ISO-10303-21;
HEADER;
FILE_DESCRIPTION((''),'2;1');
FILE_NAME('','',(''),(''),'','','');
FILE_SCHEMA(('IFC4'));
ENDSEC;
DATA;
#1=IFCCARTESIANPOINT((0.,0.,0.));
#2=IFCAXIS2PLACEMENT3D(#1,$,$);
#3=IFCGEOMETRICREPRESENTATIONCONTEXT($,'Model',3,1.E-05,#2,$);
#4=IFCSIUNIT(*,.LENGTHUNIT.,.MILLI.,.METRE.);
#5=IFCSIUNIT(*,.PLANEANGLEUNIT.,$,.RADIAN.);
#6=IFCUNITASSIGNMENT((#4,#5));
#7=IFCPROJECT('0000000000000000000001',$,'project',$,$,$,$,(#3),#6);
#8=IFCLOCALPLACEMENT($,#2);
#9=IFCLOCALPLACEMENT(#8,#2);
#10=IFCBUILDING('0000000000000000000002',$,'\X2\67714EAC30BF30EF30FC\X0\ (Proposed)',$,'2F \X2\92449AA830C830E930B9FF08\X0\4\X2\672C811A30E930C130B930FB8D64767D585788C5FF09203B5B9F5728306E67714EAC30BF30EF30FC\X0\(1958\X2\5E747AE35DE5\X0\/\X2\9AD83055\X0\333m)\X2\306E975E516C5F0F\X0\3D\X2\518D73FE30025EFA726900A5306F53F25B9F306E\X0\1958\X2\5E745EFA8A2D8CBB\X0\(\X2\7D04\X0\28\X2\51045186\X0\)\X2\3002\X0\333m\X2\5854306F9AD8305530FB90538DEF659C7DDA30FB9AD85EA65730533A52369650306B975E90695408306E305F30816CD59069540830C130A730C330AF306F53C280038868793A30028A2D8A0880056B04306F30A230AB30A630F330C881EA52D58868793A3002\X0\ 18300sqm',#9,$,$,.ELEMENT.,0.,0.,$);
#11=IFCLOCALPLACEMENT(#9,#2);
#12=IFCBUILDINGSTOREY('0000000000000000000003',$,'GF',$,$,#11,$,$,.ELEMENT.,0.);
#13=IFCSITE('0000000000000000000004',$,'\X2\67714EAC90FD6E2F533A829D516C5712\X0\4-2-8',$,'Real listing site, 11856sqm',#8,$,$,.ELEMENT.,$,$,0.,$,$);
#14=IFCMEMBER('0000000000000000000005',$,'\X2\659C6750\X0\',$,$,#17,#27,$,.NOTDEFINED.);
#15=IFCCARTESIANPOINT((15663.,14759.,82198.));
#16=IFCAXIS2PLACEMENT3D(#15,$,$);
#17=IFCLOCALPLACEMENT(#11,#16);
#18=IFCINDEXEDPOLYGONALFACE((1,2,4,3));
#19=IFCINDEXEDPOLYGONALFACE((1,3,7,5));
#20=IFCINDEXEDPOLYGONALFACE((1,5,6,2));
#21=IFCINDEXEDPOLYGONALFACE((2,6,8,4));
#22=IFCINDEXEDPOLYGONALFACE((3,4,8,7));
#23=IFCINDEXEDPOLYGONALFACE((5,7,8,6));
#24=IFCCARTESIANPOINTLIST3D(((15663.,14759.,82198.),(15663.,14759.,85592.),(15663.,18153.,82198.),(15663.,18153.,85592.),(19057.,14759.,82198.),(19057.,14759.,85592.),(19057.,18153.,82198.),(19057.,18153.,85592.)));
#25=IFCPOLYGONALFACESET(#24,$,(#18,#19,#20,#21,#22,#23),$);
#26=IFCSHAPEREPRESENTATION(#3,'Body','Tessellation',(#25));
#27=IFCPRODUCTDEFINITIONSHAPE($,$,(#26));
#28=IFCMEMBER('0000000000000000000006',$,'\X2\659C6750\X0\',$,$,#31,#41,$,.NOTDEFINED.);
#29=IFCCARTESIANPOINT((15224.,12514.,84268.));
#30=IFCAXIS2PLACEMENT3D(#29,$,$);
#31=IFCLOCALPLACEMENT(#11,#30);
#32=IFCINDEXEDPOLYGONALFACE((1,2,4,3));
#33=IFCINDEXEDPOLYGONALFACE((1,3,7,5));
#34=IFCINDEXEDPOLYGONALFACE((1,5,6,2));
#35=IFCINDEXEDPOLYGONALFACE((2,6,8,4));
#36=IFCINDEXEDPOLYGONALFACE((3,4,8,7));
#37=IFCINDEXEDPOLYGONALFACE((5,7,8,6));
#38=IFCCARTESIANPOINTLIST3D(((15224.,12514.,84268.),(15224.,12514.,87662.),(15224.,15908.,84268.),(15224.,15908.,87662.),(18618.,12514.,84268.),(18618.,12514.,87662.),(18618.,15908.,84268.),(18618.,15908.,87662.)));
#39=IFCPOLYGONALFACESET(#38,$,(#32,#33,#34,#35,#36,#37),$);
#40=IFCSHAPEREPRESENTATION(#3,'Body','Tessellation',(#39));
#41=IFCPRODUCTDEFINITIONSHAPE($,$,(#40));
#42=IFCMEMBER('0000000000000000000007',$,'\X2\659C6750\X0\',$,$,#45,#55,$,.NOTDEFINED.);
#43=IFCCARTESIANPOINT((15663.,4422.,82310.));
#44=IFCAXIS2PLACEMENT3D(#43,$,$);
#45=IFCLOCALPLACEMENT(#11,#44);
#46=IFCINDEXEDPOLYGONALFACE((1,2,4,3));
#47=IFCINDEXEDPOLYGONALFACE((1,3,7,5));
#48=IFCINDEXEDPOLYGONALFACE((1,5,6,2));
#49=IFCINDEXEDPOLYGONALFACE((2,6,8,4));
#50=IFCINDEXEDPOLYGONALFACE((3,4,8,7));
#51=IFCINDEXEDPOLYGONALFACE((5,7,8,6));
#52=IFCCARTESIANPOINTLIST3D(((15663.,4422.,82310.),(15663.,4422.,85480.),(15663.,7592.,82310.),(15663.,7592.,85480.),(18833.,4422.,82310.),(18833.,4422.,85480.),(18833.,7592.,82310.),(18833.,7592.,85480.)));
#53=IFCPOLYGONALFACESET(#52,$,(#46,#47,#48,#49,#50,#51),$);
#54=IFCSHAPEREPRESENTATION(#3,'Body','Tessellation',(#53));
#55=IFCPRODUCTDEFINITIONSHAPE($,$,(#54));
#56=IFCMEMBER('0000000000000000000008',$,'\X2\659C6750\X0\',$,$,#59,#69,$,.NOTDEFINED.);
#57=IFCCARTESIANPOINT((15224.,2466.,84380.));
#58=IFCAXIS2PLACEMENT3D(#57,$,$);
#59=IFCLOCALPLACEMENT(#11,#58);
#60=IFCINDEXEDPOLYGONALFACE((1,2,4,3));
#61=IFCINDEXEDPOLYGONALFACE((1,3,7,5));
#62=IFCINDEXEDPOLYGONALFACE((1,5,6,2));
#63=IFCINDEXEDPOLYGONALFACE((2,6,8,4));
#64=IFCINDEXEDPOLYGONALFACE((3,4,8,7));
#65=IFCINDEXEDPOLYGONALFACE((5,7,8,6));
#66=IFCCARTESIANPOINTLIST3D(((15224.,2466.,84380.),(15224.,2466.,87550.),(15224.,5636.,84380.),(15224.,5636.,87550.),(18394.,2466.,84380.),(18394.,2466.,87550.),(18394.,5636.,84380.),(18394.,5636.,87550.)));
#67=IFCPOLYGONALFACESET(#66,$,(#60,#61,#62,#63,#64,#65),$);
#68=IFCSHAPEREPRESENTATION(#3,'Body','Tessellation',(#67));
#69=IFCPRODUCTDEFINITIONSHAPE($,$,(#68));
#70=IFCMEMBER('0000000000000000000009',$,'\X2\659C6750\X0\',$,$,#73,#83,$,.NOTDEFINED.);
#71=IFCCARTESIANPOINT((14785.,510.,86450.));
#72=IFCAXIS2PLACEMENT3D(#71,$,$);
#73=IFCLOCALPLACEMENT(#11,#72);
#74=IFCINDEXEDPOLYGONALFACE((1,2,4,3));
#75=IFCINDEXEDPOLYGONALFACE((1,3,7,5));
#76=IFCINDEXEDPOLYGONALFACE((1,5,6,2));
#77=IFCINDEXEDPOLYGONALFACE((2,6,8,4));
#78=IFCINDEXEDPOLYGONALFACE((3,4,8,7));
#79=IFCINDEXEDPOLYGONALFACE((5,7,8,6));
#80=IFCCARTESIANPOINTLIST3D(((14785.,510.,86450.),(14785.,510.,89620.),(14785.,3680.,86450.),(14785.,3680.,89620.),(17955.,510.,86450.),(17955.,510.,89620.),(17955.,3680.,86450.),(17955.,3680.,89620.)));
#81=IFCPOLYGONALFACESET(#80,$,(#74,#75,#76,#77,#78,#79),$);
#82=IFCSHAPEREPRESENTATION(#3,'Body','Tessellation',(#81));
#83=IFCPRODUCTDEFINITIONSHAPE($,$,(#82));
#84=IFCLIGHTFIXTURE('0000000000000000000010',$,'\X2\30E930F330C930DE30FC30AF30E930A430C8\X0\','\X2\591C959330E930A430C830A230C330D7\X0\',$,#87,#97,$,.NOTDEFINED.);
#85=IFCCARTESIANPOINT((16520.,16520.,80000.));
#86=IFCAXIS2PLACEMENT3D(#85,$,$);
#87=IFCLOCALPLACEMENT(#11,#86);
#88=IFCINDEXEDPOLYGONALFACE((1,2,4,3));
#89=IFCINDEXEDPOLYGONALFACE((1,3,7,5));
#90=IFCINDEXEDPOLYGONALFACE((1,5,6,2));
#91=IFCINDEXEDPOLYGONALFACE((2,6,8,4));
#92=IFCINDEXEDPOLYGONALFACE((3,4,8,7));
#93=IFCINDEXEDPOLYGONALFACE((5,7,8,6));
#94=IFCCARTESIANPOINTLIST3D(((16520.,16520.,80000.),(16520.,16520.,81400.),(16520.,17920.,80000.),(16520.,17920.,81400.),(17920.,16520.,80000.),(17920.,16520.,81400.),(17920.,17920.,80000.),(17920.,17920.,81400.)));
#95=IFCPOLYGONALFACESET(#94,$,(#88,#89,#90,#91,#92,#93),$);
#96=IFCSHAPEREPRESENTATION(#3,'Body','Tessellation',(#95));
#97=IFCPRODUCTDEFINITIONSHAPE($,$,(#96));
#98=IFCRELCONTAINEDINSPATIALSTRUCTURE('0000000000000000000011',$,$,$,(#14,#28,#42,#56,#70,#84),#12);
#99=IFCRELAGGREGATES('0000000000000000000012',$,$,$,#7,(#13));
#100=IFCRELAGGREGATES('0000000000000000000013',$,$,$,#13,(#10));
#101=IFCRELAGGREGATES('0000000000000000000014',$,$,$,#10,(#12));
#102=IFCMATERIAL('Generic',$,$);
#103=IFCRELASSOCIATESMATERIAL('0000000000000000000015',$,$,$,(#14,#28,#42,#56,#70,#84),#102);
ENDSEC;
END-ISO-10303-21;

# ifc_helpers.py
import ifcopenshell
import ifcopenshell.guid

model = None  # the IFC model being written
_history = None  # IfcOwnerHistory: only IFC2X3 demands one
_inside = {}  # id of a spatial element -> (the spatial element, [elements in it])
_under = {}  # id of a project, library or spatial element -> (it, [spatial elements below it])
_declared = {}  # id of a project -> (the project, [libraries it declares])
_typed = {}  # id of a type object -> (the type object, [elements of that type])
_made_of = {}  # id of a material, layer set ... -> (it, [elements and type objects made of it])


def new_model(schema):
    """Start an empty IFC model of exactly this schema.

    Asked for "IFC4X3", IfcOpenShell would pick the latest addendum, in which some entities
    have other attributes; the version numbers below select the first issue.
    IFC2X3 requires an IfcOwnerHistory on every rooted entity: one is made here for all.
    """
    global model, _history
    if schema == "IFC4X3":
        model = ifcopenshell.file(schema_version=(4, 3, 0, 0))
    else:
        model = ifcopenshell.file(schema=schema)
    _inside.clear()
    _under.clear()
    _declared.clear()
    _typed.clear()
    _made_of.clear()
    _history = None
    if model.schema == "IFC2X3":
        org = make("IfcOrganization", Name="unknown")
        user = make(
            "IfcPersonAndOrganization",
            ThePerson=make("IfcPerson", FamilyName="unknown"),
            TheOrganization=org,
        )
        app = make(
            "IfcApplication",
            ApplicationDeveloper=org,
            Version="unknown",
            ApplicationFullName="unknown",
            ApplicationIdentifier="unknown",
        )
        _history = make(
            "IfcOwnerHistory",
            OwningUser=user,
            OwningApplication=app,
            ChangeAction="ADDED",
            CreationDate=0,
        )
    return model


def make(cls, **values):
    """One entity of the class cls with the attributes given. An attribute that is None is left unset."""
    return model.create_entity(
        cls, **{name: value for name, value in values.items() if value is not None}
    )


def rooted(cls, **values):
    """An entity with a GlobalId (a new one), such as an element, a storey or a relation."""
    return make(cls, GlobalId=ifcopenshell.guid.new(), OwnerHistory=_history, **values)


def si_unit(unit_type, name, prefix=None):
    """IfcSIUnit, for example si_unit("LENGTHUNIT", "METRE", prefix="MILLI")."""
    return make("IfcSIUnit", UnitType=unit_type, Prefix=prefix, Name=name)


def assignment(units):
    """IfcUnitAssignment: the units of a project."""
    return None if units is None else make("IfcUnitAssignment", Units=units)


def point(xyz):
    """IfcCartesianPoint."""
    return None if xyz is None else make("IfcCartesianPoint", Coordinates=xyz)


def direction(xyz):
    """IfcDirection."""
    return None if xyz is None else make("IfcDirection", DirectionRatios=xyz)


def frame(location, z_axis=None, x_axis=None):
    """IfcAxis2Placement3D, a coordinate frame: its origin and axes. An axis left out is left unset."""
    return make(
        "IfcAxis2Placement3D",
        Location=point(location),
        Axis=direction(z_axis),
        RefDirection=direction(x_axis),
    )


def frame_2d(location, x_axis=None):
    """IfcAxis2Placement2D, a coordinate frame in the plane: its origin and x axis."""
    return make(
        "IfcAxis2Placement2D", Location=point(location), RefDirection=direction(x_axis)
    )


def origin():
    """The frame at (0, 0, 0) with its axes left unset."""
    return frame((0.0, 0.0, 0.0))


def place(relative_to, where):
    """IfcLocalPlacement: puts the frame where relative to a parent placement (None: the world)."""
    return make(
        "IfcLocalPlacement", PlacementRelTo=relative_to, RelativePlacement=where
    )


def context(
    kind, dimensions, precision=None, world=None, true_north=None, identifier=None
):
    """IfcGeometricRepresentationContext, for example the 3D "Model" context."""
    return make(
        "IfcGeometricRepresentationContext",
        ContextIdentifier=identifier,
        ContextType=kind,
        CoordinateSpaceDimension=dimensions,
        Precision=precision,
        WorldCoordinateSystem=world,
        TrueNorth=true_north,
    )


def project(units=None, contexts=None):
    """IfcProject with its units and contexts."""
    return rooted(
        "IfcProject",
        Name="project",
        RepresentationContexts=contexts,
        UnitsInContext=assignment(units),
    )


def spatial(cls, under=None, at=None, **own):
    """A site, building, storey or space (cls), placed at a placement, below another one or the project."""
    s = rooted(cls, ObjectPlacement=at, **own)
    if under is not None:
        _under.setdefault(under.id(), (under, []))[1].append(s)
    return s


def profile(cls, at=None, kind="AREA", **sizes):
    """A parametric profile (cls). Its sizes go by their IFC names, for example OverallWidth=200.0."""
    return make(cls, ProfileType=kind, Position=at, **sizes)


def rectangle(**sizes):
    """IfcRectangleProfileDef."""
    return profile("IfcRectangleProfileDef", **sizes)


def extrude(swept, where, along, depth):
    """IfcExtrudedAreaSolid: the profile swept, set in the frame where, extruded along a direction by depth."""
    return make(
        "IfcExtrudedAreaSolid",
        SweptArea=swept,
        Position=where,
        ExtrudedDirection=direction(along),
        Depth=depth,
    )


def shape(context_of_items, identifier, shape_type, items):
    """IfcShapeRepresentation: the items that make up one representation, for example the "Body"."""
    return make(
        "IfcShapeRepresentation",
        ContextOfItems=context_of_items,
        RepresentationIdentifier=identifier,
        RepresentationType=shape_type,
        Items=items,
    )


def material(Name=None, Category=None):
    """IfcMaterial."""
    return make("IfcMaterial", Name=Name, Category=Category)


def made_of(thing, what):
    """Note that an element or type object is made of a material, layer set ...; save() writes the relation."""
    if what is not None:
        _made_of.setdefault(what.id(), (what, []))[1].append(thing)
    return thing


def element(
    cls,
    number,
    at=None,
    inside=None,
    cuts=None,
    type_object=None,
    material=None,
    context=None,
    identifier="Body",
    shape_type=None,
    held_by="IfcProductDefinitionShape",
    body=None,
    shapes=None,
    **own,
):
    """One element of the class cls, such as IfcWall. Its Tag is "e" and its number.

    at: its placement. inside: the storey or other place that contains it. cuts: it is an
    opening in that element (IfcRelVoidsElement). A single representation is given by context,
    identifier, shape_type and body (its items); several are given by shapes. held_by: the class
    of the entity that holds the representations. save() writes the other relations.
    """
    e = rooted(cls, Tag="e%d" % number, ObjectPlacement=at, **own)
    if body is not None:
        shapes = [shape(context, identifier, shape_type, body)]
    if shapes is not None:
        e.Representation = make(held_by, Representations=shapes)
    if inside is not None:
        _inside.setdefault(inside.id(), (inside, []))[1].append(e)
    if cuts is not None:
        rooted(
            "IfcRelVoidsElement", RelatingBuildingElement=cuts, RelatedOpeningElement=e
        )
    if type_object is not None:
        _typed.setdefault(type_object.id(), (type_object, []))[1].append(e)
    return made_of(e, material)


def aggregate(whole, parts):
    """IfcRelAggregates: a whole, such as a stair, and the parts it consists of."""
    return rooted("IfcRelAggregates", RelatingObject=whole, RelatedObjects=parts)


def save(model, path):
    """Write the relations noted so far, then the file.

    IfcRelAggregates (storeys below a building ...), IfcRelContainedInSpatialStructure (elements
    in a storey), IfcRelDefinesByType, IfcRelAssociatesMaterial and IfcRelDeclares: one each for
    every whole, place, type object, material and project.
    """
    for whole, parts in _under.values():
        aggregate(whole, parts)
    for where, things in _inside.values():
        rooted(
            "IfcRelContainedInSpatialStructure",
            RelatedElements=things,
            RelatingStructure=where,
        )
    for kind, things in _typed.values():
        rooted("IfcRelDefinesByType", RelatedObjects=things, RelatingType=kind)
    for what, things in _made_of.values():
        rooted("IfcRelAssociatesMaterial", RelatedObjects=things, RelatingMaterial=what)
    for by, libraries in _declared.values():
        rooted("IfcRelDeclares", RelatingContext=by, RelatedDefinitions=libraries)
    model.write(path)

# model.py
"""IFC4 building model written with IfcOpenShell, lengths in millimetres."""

from ifc_helpers import new_model, si_unit, frame, frame_2d, origin, place, context, project, spatial, rectangle, extrude, material, element, save


model = new_model("IFC4")

# Units and contexts
model_context = context("Model", 3, precision=1e-05, world=origin())
ifc_project = project(units=[si_unit("LENGTHUNIT", "METRE", prefix="MILLI"), si_unit("PLANEANGLEUNIT", "RADIAN")], contexts=[model_context])

# Site, building, storey
site_placement = place(None, origin())
site = spatial("IfcSite", under=ifc_project, at=site_placement, Name="東京都港区芝公園4-2-8", ObjectType="Real listing site, 11856sqm", CompositionType="ELEMENT", RefElevation=0.0)
building_placement = place(site_placement, origin())
building = spatial("IfcBuilding", under=site, at=building_placement, Name="東京タワー (Proposed)", ObjectType="2F 鉄骨トラス（4本脚ラチス・赤白塗装）※実在の東京タワー(1958年竣工/高さ333m)の非公式3D再現。建物¥は史実の1958年建設費(約28億円)。333m塔は高さ・道路斜線・高度地区制限に非適合のため法適合チェックは参考表示。設計者欄はアカウント自動表示。 18300sqm", CompositionType="ELEMENT", ElevationOfRefHeight=0.0, ElevationOfTerrain=0.0)
storey_placement = place(building_placement, origin())
storey = spatial("IfcBuildingStorey", under=building, at=storey_placement, Name="GF", CompositionType="ELEMENT", Elevation=0.0)

# Shared definitions
ifc_material = material(Name="Generic")

# Members
member_1_placement = place(storey_placement, frame((15663.0, 14759.0, 82198.0)))
element("IfcMember", 1, at=member_1_placement, inside=storey, material=ifc_material, Name="斜材", PredefinedType="NOTDEFINED", context=model_context, shape_type="SweptSolid", body=[
    extrude(rectangle(XDim=3394.0, YDim=3394.0, at=frame_2d((1697.0, 1697.0))), frame((15663.0, 14759.0, 82198.0)), (0.0, 0.0, 1.0), 3394.0),
])
member_2_placement = place(storey_placement, frame((15224.0, 12514.0, 84268.0)))
element("IfcMember", 2, at=member_2_placement, inside=storey, material=ifc_material, Name="斜材", PredefinedType="NOTDEFINED", context=model_context, shape_type="SweptSolid", body=[
    extrude(rectangle(XDim=3394.0, YDim=3394.0, at=frame_2d((1697.0, 1697.0))), frame((15224.0, 12514.0, 84268.0)), (0.0, 0.0, 1.0), 3394.0),
])
member_3_placement = place(storey_placement, frame((15663.0, 4422.0, 82310.0)))
element("IfcMember", 3, at=member_3_placement, inside=storey, material=ifc_material, Name="斜材", PredefinedType="NOTDEFINED", context=model_context, shape_type="SweptSolid", body=[
    extrude(rectangle(XDim=3170.0, YDim=3170.0, at=frame_2d((1585.0, 1585.0))), frame((15663.0, 4422.0, 82310.0)), (0.0, 0.0, 1.0), 3170.0),
])
member_4_placement = place(storey_placement, frame((15224.0, 2466.0, 84380.0)))
element("IfcMember", 4, at=member_4_placement, inside=storey, material=ifc_material, Name="斜材", PredefinedType="NOTDEFINED", context=model_context, shape_type="SweptSolid", body=[
    extrude(rectangle(XDim=3170.0, YDim=3170.0, at=frame_2d((1585.0, 1585.0))), frame((15224.0, 2466.0, 84380.0)), (0.0, 0.0, 1.0), 3170.0),
])
member_5_placement = place(storey_placement, frame((14785.0, 510.0, 86450.0)))
element("IfcMember", 5, at=member_5_placement, inside=storey, material=ifc_material, Name="斜材", PredefinedType="NOTDEFINED", context=model_context, shape_type="SweptSolid", body=[
    extrude(rectangle(XDim=3170.0, YDim=3170.0, at=frame_2d((1585.0, 1585.0))), frame((14785.0, 510.0, 86450.0)), (0.0, 0.0, 1.0), 3170.0),
])

# Light fixture
light_fixture_placement = place(storey_placement, frame((16520.0, 16520.0, 80000.0)))
element("IfcLightFixture", 6, at=light_fixture_placement, inside=storey, material=ifc_material, Name="ランドマークライト", Description="夜間ライトアップ", PredefinedType="NOTDEFINED", context=model_context, shape_type="SweptSolid", body=[
    extrude(rectangle(XDim=1400.0, YDim=1400.0, at=frame_2d((700.0, 700.0))), frame((16520.0, 16520.0, 80000.0)), (0.0, 0.0, 1.0), 1400.0),
])

save(model, "model.ifc")
